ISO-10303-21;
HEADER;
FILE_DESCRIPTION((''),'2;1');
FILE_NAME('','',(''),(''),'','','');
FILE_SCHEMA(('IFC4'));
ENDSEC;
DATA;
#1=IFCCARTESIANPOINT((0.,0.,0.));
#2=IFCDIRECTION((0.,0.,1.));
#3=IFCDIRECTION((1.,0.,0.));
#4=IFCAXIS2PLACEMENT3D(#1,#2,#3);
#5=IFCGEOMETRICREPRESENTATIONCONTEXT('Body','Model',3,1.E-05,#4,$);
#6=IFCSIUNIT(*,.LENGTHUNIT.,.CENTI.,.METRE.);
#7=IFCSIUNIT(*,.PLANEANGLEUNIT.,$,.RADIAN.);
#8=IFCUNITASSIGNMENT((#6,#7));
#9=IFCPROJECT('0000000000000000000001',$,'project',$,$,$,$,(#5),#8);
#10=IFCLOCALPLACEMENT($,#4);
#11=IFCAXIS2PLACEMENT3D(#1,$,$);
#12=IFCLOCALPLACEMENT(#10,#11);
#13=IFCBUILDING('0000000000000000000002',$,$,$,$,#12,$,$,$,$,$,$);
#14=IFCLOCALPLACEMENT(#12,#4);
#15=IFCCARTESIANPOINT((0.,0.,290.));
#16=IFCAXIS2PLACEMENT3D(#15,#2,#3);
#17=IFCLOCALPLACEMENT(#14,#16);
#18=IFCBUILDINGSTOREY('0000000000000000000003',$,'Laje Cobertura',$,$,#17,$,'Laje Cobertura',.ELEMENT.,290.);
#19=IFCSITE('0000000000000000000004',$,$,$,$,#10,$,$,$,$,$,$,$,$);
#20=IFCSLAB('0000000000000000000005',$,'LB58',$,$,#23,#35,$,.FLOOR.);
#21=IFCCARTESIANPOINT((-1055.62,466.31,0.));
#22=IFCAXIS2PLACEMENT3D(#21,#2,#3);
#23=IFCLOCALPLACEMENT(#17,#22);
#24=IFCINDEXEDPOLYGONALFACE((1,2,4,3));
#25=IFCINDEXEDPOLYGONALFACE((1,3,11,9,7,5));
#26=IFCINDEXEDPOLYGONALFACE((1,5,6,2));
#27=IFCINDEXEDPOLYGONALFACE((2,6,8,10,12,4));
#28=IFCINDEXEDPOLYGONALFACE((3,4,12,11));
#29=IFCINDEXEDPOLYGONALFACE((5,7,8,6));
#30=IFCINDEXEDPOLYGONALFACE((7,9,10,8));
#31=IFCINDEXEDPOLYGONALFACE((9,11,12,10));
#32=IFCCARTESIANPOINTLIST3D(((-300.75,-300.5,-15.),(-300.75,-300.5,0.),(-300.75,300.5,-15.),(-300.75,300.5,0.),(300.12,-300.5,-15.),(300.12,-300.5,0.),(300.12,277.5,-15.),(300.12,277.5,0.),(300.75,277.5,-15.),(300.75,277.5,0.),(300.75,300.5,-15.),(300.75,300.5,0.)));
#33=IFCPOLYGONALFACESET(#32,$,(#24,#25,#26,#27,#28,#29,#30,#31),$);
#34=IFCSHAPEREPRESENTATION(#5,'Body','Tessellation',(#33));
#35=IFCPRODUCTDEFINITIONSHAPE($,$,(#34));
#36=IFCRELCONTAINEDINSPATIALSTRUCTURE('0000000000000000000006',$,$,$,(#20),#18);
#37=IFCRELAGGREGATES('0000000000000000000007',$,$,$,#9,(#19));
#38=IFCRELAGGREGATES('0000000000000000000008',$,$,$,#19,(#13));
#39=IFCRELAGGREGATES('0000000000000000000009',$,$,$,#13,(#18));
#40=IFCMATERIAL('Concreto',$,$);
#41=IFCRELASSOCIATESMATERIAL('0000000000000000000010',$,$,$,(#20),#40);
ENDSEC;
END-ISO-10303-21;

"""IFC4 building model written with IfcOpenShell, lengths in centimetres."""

from ifc_helpers import new_model, si_unit, frame, origin, origin_with_axes, place, context, project, spatial, polyline, outline, extrude, material, element, save


model = new_model("IFC4")

# Units and contexts
model_context = context("Model", 3, precision=1e-05, world=origin_with_axes(), identifier="Body")
ifc_project = project(units=[si_unit("LENGTHUNIT", "METRE", prefix="CENTI"), si_unit("PLANEANGLEUNIT", "RADIAN")], contexts=[model_context])

# Site, building, storey
site_placement = place(None, origin_with_axes())
site = spatial("IfcSite", under=ifc_project, at=site_placement)
building_placement = place(site_placement, origin())
building = spatial("IfcBuilding", under=site, at=building_placement)
placement = place(building_placement, origin_with_axes())
storey_placement = place(placement, frame((0.0, 0.0, 290.0), z_axis=(0.0, 0.0, 1.0), x_axis=(1.0, 0.0, 0.0)))
storey = spatial("IfcBuildingStorey", under=building, at=storey_placement, Name="Laje Cobertura", LongName="Laje Cobertura", CompositionType="ELEMENT", Elevation=290.0)

# Shared definitions
ifc_material = material(Name="Concreto")

# Slab
slab_1_placement = place(storey_placement, frame((-1055.62, 466.31, 0.0), z_axis=(0.0, 0.0, 1.0), x_axis=(1.0, 0.0, 0.0)))
element("IfcSlab", 1, at=slab_1_placement, inside=storey, material=ifc_material, Name="LB58", PredefinedType="FLOOR", context=model_context, shape_type="SolidModel", body=[
    extrude(outline(polyline([(300.12, 277.5), (300.75, 277.5), (300.75, 300.5), (-300.75, 300.5), (-300.75, -300.5), (300.12, -300.5), (300.12, 277.5), (300.12, 277.5)])), frame((0.0, 0.0, -15.0), z_axis=(0.0, 0.0, 1.0), x_axis=(1.0, 0.0, 0.0)), (0.0, 0.0, 1.0), 15.0),
])

save(model, "model.ifc")
